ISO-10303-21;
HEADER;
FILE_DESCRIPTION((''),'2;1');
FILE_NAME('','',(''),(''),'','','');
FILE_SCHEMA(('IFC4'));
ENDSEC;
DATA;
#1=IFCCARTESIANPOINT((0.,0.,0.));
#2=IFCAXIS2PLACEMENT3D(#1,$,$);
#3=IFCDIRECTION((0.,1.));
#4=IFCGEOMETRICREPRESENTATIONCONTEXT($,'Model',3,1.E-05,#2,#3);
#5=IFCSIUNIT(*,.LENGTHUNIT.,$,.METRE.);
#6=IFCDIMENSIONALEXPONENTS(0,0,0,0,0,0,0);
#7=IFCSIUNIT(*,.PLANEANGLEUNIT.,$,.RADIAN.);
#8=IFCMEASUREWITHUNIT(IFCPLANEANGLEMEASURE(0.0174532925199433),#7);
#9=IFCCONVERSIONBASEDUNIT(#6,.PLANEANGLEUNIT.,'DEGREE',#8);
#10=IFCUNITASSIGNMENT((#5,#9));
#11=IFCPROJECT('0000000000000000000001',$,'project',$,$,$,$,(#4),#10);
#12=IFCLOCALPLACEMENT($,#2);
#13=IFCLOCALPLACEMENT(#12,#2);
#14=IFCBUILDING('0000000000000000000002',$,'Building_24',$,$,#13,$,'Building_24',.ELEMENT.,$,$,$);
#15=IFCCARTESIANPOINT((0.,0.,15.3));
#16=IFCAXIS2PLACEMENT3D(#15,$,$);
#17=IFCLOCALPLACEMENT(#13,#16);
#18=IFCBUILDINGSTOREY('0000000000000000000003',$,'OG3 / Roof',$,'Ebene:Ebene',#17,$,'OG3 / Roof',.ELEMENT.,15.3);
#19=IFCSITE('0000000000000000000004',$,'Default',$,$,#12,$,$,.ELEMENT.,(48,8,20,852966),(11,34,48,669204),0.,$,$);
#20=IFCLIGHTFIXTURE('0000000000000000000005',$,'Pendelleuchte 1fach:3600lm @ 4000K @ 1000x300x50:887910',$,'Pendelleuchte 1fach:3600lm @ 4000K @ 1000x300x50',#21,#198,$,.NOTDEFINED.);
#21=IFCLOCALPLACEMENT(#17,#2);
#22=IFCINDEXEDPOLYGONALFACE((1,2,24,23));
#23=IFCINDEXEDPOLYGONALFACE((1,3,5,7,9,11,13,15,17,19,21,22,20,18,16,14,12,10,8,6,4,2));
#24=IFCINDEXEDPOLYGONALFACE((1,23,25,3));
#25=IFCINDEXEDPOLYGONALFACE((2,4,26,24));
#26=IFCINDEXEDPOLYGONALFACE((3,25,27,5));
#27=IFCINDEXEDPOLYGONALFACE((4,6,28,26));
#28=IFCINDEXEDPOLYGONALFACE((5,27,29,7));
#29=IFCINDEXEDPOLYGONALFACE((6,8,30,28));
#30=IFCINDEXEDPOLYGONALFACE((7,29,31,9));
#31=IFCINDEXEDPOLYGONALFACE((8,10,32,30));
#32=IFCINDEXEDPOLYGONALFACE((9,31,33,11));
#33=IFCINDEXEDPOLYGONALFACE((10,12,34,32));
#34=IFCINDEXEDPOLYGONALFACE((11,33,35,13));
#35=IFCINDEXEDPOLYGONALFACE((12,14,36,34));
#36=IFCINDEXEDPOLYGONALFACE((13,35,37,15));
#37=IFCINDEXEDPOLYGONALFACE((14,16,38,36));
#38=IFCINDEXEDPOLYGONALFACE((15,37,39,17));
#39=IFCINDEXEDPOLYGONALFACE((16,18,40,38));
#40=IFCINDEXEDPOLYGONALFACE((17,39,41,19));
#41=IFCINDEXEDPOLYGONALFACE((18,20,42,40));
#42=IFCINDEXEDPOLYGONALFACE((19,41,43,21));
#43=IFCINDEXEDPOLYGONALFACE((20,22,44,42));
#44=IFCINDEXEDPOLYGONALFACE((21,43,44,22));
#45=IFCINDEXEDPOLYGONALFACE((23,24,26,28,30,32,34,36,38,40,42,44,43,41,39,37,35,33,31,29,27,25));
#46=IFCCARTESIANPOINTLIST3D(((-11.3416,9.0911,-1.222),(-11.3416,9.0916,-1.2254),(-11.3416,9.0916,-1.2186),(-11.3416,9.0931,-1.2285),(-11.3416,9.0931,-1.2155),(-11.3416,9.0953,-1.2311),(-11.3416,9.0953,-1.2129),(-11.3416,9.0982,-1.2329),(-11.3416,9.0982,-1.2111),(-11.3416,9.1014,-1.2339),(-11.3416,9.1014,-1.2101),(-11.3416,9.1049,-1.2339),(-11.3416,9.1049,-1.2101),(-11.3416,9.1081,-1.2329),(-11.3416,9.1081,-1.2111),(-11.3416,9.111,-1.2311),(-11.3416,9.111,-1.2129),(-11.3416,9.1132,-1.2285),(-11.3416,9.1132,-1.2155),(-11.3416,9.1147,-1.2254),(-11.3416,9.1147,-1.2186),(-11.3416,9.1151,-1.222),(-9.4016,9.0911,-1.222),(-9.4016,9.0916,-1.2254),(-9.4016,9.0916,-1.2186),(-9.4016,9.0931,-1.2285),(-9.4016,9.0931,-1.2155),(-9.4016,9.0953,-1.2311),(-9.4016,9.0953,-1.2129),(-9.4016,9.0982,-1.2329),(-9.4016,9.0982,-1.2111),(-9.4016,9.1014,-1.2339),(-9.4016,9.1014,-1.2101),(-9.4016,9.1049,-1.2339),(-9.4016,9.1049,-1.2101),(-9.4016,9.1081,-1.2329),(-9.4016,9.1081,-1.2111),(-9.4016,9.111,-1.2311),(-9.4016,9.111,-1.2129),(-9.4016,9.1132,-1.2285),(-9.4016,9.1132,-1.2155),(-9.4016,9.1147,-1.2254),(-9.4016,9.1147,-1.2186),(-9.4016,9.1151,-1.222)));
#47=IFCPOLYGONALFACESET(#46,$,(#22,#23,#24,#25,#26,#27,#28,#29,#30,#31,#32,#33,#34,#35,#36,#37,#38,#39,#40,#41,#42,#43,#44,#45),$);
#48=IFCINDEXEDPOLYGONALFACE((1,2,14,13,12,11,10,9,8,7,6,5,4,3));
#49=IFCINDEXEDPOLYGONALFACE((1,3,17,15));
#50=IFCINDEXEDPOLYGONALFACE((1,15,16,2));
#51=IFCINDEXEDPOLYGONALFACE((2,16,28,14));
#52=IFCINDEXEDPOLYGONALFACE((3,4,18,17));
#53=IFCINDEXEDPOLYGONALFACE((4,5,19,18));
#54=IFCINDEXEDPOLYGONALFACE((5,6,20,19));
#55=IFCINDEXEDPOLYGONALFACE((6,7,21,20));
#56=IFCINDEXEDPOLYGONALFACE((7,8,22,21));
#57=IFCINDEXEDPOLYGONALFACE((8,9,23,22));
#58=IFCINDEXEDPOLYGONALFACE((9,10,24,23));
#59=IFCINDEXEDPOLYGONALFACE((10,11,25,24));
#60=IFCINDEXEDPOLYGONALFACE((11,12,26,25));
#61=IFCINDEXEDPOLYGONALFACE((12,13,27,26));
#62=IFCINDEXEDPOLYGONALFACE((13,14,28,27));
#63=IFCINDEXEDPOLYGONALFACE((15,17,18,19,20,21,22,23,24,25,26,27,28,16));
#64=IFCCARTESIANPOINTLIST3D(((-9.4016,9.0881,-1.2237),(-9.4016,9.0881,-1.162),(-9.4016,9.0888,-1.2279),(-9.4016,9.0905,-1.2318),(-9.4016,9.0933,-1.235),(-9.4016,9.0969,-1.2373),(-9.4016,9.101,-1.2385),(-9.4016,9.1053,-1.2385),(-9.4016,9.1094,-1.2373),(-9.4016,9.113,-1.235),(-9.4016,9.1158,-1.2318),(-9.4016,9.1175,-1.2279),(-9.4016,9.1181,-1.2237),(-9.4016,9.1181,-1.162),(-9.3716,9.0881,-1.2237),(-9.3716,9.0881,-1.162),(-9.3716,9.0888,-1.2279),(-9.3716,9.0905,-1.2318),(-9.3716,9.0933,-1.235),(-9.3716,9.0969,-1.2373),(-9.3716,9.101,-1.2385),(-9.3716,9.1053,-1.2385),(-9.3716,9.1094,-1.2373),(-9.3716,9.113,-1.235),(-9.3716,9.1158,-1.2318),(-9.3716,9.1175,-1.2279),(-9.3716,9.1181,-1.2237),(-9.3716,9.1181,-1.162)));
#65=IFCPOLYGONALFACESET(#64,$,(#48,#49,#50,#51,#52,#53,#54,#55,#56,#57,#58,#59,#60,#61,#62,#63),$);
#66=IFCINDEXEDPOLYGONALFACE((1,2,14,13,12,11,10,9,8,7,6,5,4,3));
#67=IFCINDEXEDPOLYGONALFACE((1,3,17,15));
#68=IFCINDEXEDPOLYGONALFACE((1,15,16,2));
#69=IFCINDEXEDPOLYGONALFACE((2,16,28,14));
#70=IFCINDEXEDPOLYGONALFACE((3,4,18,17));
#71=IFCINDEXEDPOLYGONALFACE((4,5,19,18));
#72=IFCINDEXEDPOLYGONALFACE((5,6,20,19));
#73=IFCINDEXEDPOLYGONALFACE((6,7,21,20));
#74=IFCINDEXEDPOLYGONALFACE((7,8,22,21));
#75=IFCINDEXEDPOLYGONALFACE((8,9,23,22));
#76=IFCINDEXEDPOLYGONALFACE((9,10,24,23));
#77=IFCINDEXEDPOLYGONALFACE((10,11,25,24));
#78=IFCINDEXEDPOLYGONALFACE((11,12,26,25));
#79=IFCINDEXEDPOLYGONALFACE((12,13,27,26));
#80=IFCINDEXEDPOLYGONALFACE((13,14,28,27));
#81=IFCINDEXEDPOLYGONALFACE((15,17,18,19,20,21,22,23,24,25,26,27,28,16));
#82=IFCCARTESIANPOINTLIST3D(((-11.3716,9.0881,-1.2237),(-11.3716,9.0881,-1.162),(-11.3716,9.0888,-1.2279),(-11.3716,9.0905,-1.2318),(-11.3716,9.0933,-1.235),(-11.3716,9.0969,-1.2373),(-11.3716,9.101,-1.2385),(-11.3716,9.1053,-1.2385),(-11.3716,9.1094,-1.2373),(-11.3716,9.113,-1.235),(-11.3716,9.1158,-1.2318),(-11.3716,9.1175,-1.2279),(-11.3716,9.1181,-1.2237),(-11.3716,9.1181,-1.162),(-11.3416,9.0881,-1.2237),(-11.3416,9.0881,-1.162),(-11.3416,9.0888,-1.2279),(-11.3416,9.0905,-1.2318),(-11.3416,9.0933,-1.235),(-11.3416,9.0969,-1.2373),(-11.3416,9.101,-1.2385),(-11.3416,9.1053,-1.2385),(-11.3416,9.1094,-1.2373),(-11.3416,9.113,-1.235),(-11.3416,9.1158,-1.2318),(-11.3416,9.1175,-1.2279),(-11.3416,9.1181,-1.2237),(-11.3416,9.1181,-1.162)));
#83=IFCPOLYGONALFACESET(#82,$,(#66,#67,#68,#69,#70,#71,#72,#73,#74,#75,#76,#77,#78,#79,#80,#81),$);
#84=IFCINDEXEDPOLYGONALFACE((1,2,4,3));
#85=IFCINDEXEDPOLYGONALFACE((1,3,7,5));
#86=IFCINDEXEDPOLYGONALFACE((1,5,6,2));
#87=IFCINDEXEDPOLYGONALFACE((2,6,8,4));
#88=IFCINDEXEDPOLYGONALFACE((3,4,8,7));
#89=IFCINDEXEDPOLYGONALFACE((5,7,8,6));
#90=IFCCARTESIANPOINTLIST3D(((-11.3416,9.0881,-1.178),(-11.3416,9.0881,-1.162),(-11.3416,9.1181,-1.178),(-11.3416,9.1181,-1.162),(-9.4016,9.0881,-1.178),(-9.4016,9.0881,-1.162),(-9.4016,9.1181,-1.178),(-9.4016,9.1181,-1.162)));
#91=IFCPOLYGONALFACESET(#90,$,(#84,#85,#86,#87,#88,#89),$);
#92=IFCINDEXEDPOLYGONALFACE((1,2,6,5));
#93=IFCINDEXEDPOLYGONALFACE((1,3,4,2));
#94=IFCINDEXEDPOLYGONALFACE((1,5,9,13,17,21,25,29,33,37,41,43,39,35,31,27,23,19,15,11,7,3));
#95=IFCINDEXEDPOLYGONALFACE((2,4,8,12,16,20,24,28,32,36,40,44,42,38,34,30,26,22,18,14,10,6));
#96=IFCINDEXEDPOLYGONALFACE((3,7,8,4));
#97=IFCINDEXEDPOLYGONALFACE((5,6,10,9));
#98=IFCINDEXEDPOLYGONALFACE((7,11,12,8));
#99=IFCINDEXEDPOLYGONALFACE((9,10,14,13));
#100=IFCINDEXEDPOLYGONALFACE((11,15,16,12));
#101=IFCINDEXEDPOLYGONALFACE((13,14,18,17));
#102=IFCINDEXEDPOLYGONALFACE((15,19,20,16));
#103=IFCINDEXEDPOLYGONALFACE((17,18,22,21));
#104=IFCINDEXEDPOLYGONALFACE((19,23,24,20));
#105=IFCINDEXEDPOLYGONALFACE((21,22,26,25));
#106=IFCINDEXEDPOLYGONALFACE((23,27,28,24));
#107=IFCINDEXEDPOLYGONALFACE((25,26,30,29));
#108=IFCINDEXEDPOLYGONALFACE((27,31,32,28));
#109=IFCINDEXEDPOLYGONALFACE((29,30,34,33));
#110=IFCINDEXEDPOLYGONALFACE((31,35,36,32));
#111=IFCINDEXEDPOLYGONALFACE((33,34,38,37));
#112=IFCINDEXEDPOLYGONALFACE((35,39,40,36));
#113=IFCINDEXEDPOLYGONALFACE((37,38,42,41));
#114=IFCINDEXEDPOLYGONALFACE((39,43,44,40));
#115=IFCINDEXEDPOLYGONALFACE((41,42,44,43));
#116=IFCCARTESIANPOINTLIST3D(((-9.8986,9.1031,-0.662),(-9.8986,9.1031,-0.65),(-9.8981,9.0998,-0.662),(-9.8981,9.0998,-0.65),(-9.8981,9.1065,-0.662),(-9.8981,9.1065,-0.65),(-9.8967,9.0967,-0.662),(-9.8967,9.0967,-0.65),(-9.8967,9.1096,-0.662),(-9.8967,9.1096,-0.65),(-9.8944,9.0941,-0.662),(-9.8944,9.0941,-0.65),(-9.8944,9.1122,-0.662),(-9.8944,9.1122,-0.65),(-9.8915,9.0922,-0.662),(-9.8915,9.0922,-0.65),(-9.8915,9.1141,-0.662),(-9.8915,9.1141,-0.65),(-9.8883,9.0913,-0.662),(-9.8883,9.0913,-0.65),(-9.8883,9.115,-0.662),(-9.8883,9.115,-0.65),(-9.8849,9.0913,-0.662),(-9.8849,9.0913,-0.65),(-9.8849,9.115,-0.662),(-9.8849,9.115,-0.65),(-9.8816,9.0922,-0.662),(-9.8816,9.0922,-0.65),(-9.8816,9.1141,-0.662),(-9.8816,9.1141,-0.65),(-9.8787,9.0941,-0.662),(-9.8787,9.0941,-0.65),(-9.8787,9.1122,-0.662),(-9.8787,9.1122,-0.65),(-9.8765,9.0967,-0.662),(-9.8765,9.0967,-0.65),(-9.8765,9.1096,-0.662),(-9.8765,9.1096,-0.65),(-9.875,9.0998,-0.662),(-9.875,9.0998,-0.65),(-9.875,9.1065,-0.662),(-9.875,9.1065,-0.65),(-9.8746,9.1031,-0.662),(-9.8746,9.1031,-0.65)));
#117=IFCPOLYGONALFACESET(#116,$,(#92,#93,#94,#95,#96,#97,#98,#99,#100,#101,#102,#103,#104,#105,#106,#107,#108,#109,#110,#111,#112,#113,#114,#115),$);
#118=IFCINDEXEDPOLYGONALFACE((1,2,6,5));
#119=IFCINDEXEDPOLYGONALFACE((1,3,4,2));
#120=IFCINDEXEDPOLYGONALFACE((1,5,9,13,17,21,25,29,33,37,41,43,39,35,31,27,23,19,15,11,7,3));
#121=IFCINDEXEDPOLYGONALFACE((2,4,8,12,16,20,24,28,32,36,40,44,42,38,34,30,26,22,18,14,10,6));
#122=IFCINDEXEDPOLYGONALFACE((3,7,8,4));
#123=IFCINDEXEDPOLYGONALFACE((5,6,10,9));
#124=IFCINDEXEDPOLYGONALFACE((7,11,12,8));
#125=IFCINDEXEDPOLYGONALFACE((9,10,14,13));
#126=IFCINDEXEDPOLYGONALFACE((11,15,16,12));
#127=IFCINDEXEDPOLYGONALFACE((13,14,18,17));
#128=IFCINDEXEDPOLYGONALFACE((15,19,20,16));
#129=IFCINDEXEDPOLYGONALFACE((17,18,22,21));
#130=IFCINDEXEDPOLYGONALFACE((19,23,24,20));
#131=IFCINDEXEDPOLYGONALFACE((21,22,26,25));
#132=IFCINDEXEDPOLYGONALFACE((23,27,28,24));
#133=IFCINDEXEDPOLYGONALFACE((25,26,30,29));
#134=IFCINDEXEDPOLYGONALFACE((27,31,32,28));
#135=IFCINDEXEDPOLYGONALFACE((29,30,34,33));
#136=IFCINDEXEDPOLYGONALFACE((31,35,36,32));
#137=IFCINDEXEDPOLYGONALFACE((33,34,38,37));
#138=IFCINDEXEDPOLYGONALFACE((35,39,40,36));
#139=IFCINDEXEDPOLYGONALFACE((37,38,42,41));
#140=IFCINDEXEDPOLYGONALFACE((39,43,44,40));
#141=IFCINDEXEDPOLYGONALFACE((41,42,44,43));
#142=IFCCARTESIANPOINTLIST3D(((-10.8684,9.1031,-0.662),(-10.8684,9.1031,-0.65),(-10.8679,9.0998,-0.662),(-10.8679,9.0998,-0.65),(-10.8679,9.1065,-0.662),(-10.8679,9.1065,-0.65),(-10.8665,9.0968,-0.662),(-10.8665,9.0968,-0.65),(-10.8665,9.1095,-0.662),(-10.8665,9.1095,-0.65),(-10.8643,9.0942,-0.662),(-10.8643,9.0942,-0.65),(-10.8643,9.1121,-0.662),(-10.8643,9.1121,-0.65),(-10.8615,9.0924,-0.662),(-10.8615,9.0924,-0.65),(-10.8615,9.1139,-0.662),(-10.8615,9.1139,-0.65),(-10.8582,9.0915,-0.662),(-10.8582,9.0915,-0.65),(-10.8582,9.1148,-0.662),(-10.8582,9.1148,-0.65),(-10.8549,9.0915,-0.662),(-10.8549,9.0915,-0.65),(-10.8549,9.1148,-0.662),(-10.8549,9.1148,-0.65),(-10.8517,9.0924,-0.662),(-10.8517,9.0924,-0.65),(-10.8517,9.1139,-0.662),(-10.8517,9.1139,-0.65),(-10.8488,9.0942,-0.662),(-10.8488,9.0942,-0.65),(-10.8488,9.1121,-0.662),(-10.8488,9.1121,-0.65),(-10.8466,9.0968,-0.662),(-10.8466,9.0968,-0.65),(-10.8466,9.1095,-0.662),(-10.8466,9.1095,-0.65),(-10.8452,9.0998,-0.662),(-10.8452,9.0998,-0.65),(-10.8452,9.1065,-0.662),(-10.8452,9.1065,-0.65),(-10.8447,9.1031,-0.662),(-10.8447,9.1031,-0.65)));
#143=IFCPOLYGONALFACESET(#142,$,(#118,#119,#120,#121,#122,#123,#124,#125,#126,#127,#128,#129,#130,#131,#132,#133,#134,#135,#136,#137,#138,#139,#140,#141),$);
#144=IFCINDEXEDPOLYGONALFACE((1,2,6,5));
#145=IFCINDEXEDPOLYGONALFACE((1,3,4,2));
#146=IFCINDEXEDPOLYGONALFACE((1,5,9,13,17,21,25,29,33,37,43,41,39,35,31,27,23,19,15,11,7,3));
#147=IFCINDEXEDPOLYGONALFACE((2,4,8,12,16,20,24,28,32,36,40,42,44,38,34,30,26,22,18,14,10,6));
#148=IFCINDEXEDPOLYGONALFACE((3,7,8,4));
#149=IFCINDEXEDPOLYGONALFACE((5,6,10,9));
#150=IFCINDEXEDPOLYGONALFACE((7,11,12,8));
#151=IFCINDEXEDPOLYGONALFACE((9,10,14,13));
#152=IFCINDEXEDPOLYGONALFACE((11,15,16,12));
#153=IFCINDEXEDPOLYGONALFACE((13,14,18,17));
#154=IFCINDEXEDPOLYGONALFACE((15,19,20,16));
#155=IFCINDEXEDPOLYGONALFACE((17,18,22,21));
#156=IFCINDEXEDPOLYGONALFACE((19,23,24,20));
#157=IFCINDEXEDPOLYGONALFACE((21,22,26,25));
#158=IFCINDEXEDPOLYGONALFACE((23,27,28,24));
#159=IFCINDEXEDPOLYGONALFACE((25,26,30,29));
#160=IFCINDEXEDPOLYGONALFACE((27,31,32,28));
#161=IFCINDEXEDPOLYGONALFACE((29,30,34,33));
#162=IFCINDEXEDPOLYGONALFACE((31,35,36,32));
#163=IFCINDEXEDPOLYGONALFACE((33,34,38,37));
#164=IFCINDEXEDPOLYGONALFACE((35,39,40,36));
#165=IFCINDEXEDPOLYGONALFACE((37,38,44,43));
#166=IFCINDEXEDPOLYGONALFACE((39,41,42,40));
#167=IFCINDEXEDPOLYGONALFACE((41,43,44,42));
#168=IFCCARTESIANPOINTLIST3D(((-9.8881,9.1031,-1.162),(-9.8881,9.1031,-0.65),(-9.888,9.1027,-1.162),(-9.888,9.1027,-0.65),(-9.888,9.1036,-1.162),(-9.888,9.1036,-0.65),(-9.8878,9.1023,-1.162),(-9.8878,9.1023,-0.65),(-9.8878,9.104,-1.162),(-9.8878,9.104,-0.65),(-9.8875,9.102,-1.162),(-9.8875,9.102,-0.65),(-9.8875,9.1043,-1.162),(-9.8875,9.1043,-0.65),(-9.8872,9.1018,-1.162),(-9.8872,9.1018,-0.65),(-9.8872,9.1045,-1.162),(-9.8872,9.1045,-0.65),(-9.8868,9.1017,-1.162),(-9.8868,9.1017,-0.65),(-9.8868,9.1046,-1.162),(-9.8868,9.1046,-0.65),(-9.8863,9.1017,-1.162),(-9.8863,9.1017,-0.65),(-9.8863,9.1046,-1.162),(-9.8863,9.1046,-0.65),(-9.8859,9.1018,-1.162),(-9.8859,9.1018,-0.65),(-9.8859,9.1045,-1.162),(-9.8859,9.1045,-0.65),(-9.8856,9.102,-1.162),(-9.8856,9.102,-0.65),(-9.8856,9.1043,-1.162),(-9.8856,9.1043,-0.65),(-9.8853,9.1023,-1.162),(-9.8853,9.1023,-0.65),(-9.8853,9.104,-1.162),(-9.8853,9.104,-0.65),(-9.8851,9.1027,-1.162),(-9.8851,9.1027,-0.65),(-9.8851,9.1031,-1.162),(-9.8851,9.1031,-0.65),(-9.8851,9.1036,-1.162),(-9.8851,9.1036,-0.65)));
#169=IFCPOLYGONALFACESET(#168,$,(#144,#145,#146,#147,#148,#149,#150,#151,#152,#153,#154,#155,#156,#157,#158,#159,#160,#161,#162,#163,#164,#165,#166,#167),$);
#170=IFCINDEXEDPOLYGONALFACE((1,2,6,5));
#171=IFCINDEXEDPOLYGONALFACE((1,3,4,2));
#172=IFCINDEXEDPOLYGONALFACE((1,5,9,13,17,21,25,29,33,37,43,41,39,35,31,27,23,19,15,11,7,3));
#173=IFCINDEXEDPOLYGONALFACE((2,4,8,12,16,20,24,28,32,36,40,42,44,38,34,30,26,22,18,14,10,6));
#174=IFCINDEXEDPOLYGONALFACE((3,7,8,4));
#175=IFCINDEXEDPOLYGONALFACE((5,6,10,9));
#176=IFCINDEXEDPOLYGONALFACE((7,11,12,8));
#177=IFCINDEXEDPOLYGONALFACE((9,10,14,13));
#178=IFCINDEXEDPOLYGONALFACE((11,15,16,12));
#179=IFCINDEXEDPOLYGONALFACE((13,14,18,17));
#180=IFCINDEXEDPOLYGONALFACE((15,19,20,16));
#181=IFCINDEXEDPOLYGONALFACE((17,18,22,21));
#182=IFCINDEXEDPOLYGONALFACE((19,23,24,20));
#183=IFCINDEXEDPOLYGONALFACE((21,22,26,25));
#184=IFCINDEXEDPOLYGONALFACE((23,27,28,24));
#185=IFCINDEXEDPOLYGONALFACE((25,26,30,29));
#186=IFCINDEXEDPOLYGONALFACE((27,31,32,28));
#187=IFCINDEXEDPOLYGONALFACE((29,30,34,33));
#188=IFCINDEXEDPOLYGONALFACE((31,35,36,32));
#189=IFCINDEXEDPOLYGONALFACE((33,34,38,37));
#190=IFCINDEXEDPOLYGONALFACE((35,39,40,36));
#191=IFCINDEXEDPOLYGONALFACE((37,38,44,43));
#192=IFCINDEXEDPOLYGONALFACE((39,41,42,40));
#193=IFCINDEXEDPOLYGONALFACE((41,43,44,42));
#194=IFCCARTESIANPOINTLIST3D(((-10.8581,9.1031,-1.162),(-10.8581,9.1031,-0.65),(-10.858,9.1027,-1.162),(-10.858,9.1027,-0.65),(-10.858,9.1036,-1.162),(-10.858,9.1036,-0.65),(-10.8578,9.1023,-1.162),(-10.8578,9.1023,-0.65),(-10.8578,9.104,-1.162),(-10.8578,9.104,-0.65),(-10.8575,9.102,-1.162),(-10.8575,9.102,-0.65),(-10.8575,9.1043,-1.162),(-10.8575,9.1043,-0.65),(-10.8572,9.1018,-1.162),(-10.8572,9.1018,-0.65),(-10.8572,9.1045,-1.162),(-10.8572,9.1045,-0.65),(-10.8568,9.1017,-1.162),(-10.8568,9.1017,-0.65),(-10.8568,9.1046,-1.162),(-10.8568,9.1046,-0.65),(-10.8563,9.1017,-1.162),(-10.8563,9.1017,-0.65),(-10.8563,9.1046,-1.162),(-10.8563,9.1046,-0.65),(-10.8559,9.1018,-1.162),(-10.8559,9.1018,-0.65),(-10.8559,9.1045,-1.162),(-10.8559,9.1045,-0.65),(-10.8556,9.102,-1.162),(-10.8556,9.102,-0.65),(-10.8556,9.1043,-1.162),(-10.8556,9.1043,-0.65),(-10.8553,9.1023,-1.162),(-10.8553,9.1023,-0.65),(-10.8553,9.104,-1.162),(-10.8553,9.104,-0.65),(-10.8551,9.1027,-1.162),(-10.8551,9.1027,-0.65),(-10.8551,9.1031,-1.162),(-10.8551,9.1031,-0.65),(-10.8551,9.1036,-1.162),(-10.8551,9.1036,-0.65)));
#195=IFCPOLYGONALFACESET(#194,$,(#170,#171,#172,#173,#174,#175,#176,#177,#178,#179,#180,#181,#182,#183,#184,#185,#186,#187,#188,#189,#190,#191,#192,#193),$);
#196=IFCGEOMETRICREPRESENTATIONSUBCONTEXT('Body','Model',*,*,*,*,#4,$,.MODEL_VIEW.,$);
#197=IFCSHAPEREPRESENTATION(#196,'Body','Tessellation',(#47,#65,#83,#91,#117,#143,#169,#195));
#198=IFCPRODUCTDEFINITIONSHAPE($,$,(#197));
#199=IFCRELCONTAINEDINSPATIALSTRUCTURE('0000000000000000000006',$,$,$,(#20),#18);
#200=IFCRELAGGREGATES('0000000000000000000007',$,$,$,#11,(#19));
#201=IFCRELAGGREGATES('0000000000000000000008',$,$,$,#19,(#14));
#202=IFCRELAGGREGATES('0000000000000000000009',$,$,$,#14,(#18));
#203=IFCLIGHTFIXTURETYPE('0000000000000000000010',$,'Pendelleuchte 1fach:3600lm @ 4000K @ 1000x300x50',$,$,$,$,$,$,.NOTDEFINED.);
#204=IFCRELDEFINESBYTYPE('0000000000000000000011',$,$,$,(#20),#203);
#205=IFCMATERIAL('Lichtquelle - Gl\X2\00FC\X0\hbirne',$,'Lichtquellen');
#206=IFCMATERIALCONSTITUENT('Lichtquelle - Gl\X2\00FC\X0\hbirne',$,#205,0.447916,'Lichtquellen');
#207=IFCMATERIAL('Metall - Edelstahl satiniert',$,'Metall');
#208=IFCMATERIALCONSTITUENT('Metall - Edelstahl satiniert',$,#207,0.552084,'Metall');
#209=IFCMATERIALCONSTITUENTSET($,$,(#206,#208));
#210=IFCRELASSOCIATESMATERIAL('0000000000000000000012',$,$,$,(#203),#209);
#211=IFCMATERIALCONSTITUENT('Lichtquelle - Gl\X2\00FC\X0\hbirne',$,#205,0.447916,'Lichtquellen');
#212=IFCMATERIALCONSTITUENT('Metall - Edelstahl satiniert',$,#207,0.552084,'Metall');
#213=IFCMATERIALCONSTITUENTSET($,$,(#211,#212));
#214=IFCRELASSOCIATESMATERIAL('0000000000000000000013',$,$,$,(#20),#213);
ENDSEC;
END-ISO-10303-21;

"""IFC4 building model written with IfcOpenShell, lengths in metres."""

from ifc_helpers import new_model, entity, si_unit, converted_unit, direction, frame, origin, place, context, subcontext, project, spatial, line, arc, indexed_curve, outline, extrude, source, transform, mapped, material, constituent, constituent_set, type_object, type_shapes, element, save


model = new_model("IFC4")

# Units and contexts
model_context = context("Model", 3, precision=1e-05, world=origin(), true_north=direction((0.0, 1.0)))
body_context = subcontext(model_context, "Body", "Model", "MODEL_VIEW")
ifc_project = project(units=[si_unit("LENGTHUNIT", "METRE"), converted_unit("PLANEANGLEUNIT", "DEGREE", entity("IfcPlaneAngleMeasure", 0.0174532925199433), si_unit("PLANEANGLEUNIT", "RADIAN"), dimensions=[0, 0, 0, 0, 0, 0, 0])], contexts=[model_context])

# Site, building, storey
site_placement = place(None, origin())
site = spatial("IfcSite", under=ifc_project, at=site_placement, Name="Default", CompositionType="ELEMENT", RefLatitude=(48, 8, 20, 852966), RefLongitude=(11, 34, 48, 669204), RefElevation=0.0)
building_placement = place(site_placement, origin())
building = spatial("IfcBuilding", under=site, at=building_placement, Name="Building_24", LongName="Building_24", CompositionType="ELEMENT")
storey_placement = place(building_placement, frame((0.0, 0.0, 15.3)))
storey = spatial("IfcBuildingStorey", under=building, at=storey_placement, Name="OG3 / Roof", ObjectType="Ebene:Ebene", LongName="OG3 / Roof", CompositionType="ELEMENT", Elevation=15.3)

# Light fixture
ifc_material_1 = material(Name="Lichtquelle - Glühbirne", Category="Lichtquellen")
ifc_constituent_1 = constituent(ifc_material_1, Name="Lichtquelle - Glühbirne", Category="Lichtquellen", fraction=0.447916)
ifc_material_2 = material(Name="Metall - Edelstahl satiniert", Category="Metall")
ifc_constituent_2 = constituent(ifc_material_2, Name="Metall - Edelstahl satiniert", Category="Metall", fraction=0.552084)
ifc_constituent_set_1 = constituent_set(constituents=[ifc_constituent_1, ifc_constituent_2])
ifc_constituent_3 = constituent(ifc_material_1, Name="Lichtquelle - Glühbirne", Category="Lichtquellen", fraction=0.447916)
ifc_constituent_4 = constituent(ifc_material_2, Name="Metall - Edelstahl satiniert", Category="Metall", fraction=0.552084)
ifc_constituent_set_2 = constituent_set(constituents=[ifc_constituent_3, ifc_constituent_4])
light_fixture_type_1 = type_object("IfcLightFixtureType", Name="Pendelleuchte 1fach:3600lm @ 4000K @ 1000x300x50", PredefinedType="NOTDEFINED", material=ifc_constituent_set_2)
shared_shape_1 = source(origin(), body_context, "Body", "SweptSolid", [
    extrude(outline(indexed_curve([(-0.012, 0.0), (0.0, -0.012), (0.012, 0.0), (0.0, 0.012)], segments=[arc(1, 2, 3), arc(3, 4, 1)], self_intersect=False)), frame((-0.97, 0.0, -0.572), z_axis=(1.0, 0.0, 0.0), x_axis=(0.0, 1.0, 0.0)), (0.0, 0.0, 1.0), 1.94),
    extrude(outline(indexed_curve([(-0.0308, -0.015), (0.0308, -0.015), (0.0308, 0.015), (-0.0308, 0.015), (-0.0458, 0.0)], segments=[line(1, 2, 3, 4), arc(4, 5, 1)], self_intersect=False)), frame((0.97, 0.0, -0.5428), z_axis=(1.0, 0.0, 0.0), x_axis=(0.0, 0.0, 1.0)), (0.0, 0.0, 1.0), 0.03),
    extrude(outline(indexed_curve([(-0.0308, -0.015), (0.0308, -0.015), (0.0308, 0.015), (-0.0308, 0.015), (-0.0458, 0.0)], segments=[line(1, 2, 3, 4), arc(4, 5, 1)], self_intersect=False)), frame((-1.0, 0.0, -0.5428), z_axis=(1.0, 0.0, 0.0), x_axis=(0.0, 0.0, 1.0)), (0.0, 0.0, 1.0), 0.03),
    extrude(outline(indexed_curve([(-0.97, -0.015), (0.97, -0.015), (0.97, 0.015), (-0.97, 0.015), (-0.97, -0.015)], self_intersect=False)), frame((0.0, 0.0, -0.528), z_axis=(0.0, 0.0, 1.0), x_axis=(-1.0, 0.0, 0.0)), (0.0, 0.0, 1.0), 0.016),
    extrude(outline(indexed_curve([(-0.012, 0.0), (0.0, -0.012), (0.012, 0.0), (0.0, 0.012)], segments=[arc(1, 2, 3), arc(3, 4, 1)], self_intersect=False)), frame((0.485, 0.0, -0.012)), (0.0, 0.0, 1.0), 0.012),
    extrude(outline(indexed_curve([(-0.0118, 0.0), (0.0, -0.0118), (0.0118, 0.0), (0.0, 0.0118)], segments=[arc(1, 2, 3), arc(3, 4, 1)], self_intersect=False)), frame((-0.485, 0.0, -0.012)), (0.0, 0.0, 1.0), 0.012),
    extrude(outline(indexed_curve([(-0.0015, 0.0), (0.0, -0.0015), (0.0015, 0.0), (0.0, 0.0015)], segments=[arc(1, 2, 3), arc(3, 4, 1)], self_intersect=False)), frame((0.485, 0.0, -0.512)), (0.0, 0.0, 1.0), 0.512),
    extrude(outline(indexed_curve([(-0.0015, 0.0), (0.0, -0.0015), (0.0015, 0.0), (0.0, 0.0015)], segments=[arc(1, 2, 3), arc(3, 4, 1)], self_intersect=False)), frame((-0.485, 0.0, -0.512)), (0.0, 0.0, 1.0), 0.512),
])
type_shapes(light_fixture_type_1, [shared_shape_1])
light_fixture_1_placement = place(storey_placement, frame((-10.3716, 9.1031, -0.65)))
element("IfcLightFixture", 1, at=light_fixture_1_placement, inside=storey, type_object=light_fixture_type_1, material=ifc_constituent_set_1, Name="Pendelleuchte 1fach:3600lm @ 4000K @ 1000x300x50:887910", ObjectType="Pendelleuchte 1fach:3600lm @ 4000K @ 1000x300x50", PredefinedType="NOTDEFINED", context=body_context, shape_type="MappedRepresentation", body=[
    mapped(shared_shape_1, transform((0.0, 0.0, 0.0), scale=1.0)),
])

save(model, "model.ifc")
